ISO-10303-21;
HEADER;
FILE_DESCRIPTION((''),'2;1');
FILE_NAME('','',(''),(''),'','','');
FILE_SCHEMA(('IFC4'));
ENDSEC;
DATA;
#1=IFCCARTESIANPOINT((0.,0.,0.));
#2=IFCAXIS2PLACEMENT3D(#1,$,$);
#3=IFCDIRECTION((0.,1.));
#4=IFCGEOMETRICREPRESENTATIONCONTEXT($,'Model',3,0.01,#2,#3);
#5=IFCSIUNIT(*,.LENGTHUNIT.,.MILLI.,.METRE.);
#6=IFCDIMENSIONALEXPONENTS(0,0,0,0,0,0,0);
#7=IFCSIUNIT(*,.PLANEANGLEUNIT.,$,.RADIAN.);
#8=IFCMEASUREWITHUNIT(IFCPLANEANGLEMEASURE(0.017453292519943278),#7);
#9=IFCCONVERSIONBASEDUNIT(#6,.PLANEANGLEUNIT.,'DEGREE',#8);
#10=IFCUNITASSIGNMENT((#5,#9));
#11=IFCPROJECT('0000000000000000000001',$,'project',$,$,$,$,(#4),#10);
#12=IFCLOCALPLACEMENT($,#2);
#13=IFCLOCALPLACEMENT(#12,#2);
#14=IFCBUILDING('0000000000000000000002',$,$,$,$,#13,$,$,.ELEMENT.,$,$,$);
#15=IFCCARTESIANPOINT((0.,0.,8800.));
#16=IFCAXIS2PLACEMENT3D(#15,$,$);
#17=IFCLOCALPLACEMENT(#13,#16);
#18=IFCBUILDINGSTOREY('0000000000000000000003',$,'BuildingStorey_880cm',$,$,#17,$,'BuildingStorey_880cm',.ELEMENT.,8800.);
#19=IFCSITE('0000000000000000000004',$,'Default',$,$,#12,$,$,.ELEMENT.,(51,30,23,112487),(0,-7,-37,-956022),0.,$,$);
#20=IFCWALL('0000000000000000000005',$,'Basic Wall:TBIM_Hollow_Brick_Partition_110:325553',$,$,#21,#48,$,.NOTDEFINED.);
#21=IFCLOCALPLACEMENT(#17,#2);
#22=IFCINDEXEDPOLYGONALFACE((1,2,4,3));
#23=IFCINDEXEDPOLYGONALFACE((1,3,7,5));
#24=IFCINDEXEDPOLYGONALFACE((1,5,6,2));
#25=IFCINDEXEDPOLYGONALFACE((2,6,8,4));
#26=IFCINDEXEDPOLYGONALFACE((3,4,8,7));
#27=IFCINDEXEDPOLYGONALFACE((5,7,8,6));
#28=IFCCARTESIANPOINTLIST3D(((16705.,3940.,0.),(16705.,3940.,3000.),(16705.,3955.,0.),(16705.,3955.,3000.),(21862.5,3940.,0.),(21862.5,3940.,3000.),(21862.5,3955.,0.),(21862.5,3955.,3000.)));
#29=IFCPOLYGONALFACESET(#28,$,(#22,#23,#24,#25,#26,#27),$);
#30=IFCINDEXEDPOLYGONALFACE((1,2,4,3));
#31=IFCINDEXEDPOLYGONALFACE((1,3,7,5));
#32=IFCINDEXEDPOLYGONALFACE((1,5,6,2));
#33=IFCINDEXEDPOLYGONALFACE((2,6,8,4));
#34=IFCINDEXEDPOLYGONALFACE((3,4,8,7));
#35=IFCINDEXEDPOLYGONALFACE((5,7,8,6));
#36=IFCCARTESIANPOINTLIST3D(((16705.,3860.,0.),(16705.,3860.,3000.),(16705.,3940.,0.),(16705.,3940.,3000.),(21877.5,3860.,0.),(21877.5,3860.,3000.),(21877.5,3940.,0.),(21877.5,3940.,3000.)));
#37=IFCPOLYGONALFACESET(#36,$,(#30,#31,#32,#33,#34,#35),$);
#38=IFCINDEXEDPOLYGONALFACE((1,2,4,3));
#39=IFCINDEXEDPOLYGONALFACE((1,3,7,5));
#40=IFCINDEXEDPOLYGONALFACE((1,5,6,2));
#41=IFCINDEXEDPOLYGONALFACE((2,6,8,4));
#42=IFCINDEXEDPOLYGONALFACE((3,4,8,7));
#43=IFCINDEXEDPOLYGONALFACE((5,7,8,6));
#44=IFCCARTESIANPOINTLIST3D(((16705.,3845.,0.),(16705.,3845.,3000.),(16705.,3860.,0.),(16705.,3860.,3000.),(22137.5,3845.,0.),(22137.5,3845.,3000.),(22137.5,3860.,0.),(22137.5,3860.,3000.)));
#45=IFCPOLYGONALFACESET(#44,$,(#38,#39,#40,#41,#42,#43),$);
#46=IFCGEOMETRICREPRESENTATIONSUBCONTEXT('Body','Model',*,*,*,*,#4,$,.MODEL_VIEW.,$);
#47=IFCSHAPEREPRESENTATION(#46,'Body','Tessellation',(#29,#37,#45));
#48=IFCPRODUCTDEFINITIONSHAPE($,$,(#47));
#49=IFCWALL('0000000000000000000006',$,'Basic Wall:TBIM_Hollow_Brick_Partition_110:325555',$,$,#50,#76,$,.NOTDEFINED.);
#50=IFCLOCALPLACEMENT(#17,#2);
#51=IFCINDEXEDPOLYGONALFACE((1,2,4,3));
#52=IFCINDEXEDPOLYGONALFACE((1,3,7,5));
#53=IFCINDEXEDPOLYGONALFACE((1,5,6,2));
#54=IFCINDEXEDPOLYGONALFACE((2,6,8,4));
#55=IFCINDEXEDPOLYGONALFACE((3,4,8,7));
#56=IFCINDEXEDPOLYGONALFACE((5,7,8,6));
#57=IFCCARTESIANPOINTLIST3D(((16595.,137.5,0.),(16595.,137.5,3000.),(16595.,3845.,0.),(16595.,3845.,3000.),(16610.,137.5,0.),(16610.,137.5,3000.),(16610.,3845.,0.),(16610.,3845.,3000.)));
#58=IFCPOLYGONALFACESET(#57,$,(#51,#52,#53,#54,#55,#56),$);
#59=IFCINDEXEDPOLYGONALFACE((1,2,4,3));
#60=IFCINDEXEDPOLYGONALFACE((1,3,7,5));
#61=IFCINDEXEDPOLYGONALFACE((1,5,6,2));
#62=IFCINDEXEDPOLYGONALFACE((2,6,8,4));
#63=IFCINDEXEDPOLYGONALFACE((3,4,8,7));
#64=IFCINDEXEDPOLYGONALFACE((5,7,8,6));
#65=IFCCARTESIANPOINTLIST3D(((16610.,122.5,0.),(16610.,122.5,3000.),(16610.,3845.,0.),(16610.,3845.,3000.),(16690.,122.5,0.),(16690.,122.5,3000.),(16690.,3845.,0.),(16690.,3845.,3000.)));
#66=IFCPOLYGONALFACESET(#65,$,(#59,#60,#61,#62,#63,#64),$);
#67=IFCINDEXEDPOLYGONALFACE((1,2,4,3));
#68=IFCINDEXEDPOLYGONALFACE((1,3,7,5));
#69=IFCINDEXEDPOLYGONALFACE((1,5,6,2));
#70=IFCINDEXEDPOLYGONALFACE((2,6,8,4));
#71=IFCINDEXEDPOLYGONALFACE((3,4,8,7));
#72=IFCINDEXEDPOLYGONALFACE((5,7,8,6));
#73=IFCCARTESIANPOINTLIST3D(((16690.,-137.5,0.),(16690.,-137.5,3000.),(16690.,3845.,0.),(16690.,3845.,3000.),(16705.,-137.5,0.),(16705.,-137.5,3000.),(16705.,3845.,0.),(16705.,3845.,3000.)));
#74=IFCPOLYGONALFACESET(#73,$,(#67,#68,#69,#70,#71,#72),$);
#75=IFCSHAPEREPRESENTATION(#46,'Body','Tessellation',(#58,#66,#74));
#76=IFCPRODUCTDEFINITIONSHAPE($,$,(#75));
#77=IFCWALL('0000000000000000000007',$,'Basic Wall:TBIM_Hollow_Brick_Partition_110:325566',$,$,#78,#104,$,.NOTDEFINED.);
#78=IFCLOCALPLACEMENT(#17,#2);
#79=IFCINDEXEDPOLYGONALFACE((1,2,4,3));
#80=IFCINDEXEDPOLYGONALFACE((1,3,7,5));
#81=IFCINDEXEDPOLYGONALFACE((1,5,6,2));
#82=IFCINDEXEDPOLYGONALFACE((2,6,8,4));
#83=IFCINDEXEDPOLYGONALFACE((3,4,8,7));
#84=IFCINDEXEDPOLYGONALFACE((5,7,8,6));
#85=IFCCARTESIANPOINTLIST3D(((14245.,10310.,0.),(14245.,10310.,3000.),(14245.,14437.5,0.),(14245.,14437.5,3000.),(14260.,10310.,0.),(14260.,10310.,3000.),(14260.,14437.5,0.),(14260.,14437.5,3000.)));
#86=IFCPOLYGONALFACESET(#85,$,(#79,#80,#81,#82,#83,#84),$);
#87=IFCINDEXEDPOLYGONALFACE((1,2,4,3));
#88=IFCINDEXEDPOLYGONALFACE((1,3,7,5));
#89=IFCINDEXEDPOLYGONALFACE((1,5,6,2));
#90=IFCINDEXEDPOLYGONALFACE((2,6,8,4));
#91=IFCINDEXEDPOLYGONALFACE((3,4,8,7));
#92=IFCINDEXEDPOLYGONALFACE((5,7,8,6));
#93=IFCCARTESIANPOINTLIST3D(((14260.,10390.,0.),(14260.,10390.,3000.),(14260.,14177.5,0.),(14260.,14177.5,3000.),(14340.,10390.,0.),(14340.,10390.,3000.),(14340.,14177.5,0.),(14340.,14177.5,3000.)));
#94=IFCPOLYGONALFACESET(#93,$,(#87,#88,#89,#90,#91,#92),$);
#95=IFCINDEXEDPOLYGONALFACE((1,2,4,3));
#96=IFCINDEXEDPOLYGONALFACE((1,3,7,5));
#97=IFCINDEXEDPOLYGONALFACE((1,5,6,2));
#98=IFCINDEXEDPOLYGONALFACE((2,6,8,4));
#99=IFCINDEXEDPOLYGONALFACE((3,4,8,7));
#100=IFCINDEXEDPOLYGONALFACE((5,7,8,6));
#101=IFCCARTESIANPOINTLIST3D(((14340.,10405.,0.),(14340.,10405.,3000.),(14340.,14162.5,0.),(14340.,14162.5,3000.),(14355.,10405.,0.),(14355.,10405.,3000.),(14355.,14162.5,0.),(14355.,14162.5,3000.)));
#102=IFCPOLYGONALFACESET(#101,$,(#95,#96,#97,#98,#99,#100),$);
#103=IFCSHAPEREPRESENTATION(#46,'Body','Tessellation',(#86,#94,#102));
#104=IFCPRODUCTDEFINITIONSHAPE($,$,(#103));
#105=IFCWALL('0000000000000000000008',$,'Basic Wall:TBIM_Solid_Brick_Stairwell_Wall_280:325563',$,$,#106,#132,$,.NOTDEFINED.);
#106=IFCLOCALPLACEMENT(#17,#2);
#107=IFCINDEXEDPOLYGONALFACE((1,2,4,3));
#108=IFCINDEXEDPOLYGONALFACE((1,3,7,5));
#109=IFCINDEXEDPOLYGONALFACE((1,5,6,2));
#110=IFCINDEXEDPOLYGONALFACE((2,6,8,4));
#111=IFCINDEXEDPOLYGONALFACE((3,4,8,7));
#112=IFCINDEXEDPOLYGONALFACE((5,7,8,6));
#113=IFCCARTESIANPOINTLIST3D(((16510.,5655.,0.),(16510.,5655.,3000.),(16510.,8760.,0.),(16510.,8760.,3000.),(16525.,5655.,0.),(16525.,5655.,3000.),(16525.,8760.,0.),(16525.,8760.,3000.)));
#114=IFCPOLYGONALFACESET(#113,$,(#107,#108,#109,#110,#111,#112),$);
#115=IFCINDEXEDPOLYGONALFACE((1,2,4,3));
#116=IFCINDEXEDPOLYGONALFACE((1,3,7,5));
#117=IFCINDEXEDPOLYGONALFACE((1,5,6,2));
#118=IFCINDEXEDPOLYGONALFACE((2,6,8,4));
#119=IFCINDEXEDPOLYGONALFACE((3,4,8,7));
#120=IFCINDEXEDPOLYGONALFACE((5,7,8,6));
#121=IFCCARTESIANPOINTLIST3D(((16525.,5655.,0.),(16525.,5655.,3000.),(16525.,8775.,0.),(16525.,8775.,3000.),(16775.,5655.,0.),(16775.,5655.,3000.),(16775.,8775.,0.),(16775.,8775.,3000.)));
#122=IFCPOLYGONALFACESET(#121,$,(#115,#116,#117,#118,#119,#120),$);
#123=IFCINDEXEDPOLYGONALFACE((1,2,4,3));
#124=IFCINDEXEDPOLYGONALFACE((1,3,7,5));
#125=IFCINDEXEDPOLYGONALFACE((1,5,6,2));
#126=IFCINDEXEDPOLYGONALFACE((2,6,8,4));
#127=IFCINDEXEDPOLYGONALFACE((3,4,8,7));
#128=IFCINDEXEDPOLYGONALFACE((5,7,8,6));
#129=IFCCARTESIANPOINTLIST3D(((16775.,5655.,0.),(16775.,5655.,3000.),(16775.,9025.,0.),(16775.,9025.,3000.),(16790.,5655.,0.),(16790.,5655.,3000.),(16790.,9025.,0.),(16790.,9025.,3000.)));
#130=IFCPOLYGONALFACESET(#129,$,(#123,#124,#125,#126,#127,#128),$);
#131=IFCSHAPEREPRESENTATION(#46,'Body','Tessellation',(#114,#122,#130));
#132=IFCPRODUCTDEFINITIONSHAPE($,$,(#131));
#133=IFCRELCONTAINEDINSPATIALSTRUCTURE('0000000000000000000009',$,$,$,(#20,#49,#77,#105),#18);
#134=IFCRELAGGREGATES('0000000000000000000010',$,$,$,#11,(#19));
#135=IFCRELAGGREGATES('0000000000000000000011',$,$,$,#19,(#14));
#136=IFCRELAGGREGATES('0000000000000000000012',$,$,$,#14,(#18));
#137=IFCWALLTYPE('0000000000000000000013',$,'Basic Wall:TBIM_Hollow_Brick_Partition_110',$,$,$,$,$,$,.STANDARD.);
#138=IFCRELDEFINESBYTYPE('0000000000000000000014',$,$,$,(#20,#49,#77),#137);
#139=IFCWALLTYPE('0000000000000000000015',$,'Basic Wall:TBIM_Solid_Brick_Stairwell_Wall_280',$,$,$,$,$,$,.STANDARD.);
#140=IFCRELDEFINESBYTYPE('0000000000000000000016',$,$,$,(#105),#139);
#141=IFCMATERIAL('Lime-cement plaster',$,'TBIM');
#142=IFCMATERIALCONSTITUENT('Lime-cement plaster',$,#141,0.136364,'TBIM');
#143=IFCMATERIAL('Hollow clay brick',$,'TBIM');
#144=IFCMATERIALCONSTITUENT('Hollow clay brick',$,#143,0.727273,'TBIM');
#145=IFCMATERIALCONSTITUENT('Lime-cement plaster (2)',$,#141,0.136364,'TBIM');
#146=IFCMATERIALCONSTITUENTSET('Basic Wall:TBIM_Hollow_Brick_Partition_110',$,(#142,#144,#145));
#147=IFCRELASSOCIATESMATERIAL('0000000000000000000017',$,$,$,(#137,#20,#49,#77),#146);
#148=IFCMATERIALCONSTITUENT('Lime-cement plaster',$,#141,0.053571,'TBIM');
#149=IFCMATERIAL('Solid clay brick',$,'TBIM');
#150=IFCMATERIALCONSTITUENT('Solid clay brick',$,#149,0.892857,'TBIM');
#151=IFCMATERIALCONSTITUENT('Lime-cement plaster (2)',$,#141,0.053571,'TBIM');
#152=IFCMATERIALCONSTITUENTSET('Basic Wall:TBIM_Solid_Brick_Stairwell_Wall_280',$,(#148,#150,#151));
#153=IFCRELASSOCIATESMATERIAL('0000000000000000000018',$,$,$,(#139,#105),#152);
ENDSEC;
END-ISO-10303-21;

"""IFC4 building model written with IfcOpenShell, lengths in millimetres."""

from ifc_helpers import new_model, entity, si_unit, converted_unit, direction, frame, origin, place, context, subcontext, project, spatial, indexed_curve, outline, extrude, material, constituent, constituent_set, type_object, element, save


model = new_model("IFC4")

# Units and contexts
model_context = context("Model", 3, precision=0.01, world=origin(), true_north=direction((0.0, 1.0)))
body_context = subcontext(model_context, "Body", "Model", "MODEL_VIEW")
ifc_project = project(units=[si_unit("LENGTHUNIT", "METRE", prefix="MILLI"), converted_unit("PLANEANGLEUNIT", "DEGREE", entity("IfcPlaneAngleMeasure", 0.017453292519943278), si_unit("PLANEANGLEUNIT", "RADIAN"), dimensions=[0, 0, 0, 0, 0, 0, 0])], contexts=[model_context])

# Site, building, storey
site_placement = place(None, origin())
site = spatial("IfcSite", under=ifc_project, at=site_placement, Name="Default", CompositionType="ELEMENT", RefLatitude=(51, 30, 23, 112487), RefLongitude=(0, -7, -37, -956022), RefElevation=0.0)
building_placement = place(site_placement, origin())
building = spatial("IfcBuilding", under=site, at=building_placement, CompositionType="ELEMENT")
storey_placement = place(building_placement, frame((0.0, 0.0, 8800.0)))
storey = spatial("IfcBuildingStorey", under=building, at=storey_placement, Name="BuildingStorey_880cm", LongName="BuildingStorey_880cm", CompositionType="ELEMENT", Elevation=8800.0)

# Shared definitions
ifc_material_1 = material(Name="Hollow clay brick", Category="TBIM")
ifc_material_2 = material(Name="Lime-cement plaster", Category="TBIM")
ifc_constituent_1 = constituent(ifc_material_2, Name="Lime-cement plaster", Category="TBIM", fraction=0.136364)
ifc_constituent_2 = constituent(ifc_material_1, Name="Hollow clay brick", Category="TBIM", fraction=0.727273)
ifc_constituent_3 = constituent(ifc_material_2, Name="Lime-cement plaster (2)", Category="TBIM", fraction=0.136364)
ifc_constituent_set_1 = constituent_set(constituents=[ifc_constituent_1, ifc_constituent_2, ifc_constituent_3], Name="Basic Wall:TBIM_Hollow_Brick_Partition_110")
wall_type_1 = type_object("IfcWallType", Name="Basic Wall:TBIM_Hollow_Brick_Partition_110", PredefinedType="STANDARD", material=ifc_constituent_set_1)

# Walls
wall_1_placement = place(storey_placement, frame((16705.0, 3900.0, 0.0)))
element("IfcWall", 1, at=wall_1_placement, inside=storey, type_object=wall_type_1, material=ifc_constituent_set_1, Name="Basic Wall:TBIM_Hollow_Brick_Partition_110:325553", PredefinedType="NOTDEFINED", context=body_context, shape_type="SweptSolid", body=[
    extrude(outline(indexed_curve([(-7.5, -2578.8), (7.5, -2578.8), (7.5, 2578.8), (-7.5, 2578.8), (-7.5, -2578.8)], self_intersect=False)), frame((2578.8, 47.5, 0.0), z_axis=(0.0, 0.0, 1.0), x_axis=(0.0, -1.0, 0.0)), (0.0, 0.0, 1.0), 3000.0),
    extrude(outline(indexed_curve([(-2586.3, -40.0), (2586.3, -40.0), (2586.3, 40.0), (-2586.3, 40.0), (-2586.3, -40.0)], self_intersect=False)), frame((2586.3, 0.0, 0.0)), (0.0, 0.0, 1.0), 3000.0),
    extrude(outline(indexed_curve([(-7.5, -2716.3), (7.5, -2716.3), (7.5, 2716.3), (-7.5, 2716.3), (-7.5, -2716.3)], self_intersect=False)), frame((2716.3, -47.5, 0.0), z_axis=(0.0, 0.0, 1.0), x_axis=(0.0, 1.0, 0.0)), (0.0, 0.0, 1.0), 3000.0),
])
wall_2_placement = place(storey_placement, frame((16650.0, 137.5, 0.0), z_axis=(0.0, 0.0, 1.0), x_axis=(0.0, 1.0, 0.0)))
element("IfcWall", 2, at=wall_2_placement, inside=storey, type_object=wall_type_1, material=ifc_constituent_set_1, Name="Basic Wall:TBIM_Hollow_Brick_Partition_110:325555", PredefinedType="NOTDEFINED", context=body_context, shape_type="SweptSolid", body=[
    extrude(outline(indexed_curve([(-7.5, -1853.8), (7.5, -1853.8), (7.5, 1853.8), (-7.5, 1853.8), (-7.5, -1853.8)], self_intersect=False)), frame((1853.8, 47.5, 0.0), z_axis=(0.0, 0.0, 1.0), x_axis=(0.0, -1.0, 0.0)), (0.0, 0.0, 1.0), 3000.0),
    extrude(outline(indexed_curve([(-1861.3, -40.0), (1861.3, -40.0), (1861.3, 40.0), (-1861.3, 40.0), (-1861.3, -40.0)], self_intersect=False)), frame((1846.3, 0.0, 0.0)), (0.0, 0.0, 1.0), 3000.0),
    extrude(outline(indexed_curve([(-7.5, -1991.3), (7.5, -1991.3), (7.5, 1991.3), (-7.5, 1991.3), (-7.5, -1991.3)], self_intersect=False)), frame((1716.3, -47.5, 0.0), z_axis=(0.0, 0.0, 1.0), x_axis=(0.0, 1.0, 0.0)), (0.0, 0.0, 1.0), 3000.0),
])

# Wall
wall_3_placement = place(storey_placement, frame((14300.0, 10405.0, 0.0), z_axis=(0.0, 0.0, 1.0), x_axis=(0.0, 1.0, 0.0)))
element("IfcWall", 3, at=wall_3_placement, inside=storey, type_object=wall_type_1, material=ifc_constituent_set_1, Name="Basic Wall:TBIM_Hollow_Brick_Partition_110:325566", PredefinedType="NOTDEFINED", context=body_context, shape_type="SweptSolid", body=[
    extrude(outline(indexed_curve([(-7.5, -2063.8), (7.5, -2063.8), (7.5, 2063.7), (-7.5, 2063.7), (-7.5, -2063.8)], self_intersect=False)), frame((1968.8, 47.5, 0.0), z_axis=(0.0, 0.0, 1.0), x_axis=(0.0, -1.0, 0.0)), (0.0, 0.0, 1.0), 3000.0),
    extrude(outline(indexed_curve([(-1893.8, -40.0), (1893.8, -40.0), (1893.8, 40.0), (-1893.8, 40.0), (-1893.8, -40.0)], self_intersect=False)), frame((1878.7, 0.0, 0.0)), (0.0, 0.0, 1.0), 3000.0),
    extrude(outline(indexed_curve([(-7.5, -1878.7), (7.5, -1878.7), (7.5, 1878.7), (-7.5, 1878.7), (-7.5, -1878.7)], self_intersect=False)), frame((1878.7, -47.5, 0.0), z_axis=(0.0, 0.0, 1.0), x_axis=(0.0, 1.0, 0.0)), (0.0, 0.0, 1.0), 3000.0),
])

# Wall
ifc_constituent_4 = constituent(ifc_material_2, Name="Lime-cement plaster", Category="TBIM", fraction=0.053571)
ifc_material_3 = material(Name="Solid clay brick", Category="TBIM")
ifc_constituent_5 = constituent(ifc_material_3, Name="Solid clay brick", Category="TBIM", fraction=0.892857)
ifc_constituent_6 = constituent(ifc_material_2, Name="Lime-cement plaster (2)", Category="TBIM", fraction=0.053571)
ifc_constituent_set_2 = constituent_set(constituents=[ifc_constituent_4, ifc_constituent_5, ifc_constituent_6], Name="Basic Wall:TBIM_Solid_Brick_Stairwell_Wall_280")
wall_type_2 = type_object("IfcWallType", Name="Basic Wall:TBIM_Solid_Brick_Stairwell_Wall_280", PredefinedType="STANDARD", material=ifc_constituent_set_2)
wall_4_placement = place(storey_placement, frame((16650.0, 5655.0, 0.0), z_axis=(0.0, 0.0, 1.0), x_axis=(0.0, 1.0, 0.0)))
element("IfcWall", 4, at=wall_4_placement, inside=storey, type_object=wall_type_2, material=ifc_constituent_set_2, Name="Basic Wall:TBIM_Solid_Brick_Stairwell_Wall_280:325563", PredefinedType="NOTDEFINED", context=body_context, shape_type="SweptSolid", body=[
    extrude(outline(indexed_curve([(-7.5, -1552.5), (7.5, -1552.5), (7.5, 1552.5), (-7.5, 1552.5), (-7.5, -1552.5)], self_intersect=False)), frame((1552.5, 132.5, 0.0), z_axis=(0.0, 0.0, 1.0), x_axis=(0.0, -1.0, 0.0)), (0.0, 0.0, 1.0), 3000.0),
    extrude(outline(indexed_curve([(-1560.0, -125.0), (1560.0, -125.0), (1560.0, 125.0), (-1560.0, 125.0), (-1560.0, -125.0)], self_intersect=False)), frame((1560.0, 0.0, 0.0)), (0.0, 0.0, 1.0), 3000.0),
    extrude(outline(indexed_curve([(-7.5, -1685.0), (7.5, -1685.0), (7.5, 1685.0), (-7.5, 1685.0), (-7.5, -1685.0)], self_intersect=False)), frame((1685.0, -132.5, 0.0), z_axis=(0.0, 0.0, 1.0), x_axis=(0.0, 1.0, 0.0)), (0.0, 0.0, 1.0), 3000.0),
])

save(model, "model.ifc")
